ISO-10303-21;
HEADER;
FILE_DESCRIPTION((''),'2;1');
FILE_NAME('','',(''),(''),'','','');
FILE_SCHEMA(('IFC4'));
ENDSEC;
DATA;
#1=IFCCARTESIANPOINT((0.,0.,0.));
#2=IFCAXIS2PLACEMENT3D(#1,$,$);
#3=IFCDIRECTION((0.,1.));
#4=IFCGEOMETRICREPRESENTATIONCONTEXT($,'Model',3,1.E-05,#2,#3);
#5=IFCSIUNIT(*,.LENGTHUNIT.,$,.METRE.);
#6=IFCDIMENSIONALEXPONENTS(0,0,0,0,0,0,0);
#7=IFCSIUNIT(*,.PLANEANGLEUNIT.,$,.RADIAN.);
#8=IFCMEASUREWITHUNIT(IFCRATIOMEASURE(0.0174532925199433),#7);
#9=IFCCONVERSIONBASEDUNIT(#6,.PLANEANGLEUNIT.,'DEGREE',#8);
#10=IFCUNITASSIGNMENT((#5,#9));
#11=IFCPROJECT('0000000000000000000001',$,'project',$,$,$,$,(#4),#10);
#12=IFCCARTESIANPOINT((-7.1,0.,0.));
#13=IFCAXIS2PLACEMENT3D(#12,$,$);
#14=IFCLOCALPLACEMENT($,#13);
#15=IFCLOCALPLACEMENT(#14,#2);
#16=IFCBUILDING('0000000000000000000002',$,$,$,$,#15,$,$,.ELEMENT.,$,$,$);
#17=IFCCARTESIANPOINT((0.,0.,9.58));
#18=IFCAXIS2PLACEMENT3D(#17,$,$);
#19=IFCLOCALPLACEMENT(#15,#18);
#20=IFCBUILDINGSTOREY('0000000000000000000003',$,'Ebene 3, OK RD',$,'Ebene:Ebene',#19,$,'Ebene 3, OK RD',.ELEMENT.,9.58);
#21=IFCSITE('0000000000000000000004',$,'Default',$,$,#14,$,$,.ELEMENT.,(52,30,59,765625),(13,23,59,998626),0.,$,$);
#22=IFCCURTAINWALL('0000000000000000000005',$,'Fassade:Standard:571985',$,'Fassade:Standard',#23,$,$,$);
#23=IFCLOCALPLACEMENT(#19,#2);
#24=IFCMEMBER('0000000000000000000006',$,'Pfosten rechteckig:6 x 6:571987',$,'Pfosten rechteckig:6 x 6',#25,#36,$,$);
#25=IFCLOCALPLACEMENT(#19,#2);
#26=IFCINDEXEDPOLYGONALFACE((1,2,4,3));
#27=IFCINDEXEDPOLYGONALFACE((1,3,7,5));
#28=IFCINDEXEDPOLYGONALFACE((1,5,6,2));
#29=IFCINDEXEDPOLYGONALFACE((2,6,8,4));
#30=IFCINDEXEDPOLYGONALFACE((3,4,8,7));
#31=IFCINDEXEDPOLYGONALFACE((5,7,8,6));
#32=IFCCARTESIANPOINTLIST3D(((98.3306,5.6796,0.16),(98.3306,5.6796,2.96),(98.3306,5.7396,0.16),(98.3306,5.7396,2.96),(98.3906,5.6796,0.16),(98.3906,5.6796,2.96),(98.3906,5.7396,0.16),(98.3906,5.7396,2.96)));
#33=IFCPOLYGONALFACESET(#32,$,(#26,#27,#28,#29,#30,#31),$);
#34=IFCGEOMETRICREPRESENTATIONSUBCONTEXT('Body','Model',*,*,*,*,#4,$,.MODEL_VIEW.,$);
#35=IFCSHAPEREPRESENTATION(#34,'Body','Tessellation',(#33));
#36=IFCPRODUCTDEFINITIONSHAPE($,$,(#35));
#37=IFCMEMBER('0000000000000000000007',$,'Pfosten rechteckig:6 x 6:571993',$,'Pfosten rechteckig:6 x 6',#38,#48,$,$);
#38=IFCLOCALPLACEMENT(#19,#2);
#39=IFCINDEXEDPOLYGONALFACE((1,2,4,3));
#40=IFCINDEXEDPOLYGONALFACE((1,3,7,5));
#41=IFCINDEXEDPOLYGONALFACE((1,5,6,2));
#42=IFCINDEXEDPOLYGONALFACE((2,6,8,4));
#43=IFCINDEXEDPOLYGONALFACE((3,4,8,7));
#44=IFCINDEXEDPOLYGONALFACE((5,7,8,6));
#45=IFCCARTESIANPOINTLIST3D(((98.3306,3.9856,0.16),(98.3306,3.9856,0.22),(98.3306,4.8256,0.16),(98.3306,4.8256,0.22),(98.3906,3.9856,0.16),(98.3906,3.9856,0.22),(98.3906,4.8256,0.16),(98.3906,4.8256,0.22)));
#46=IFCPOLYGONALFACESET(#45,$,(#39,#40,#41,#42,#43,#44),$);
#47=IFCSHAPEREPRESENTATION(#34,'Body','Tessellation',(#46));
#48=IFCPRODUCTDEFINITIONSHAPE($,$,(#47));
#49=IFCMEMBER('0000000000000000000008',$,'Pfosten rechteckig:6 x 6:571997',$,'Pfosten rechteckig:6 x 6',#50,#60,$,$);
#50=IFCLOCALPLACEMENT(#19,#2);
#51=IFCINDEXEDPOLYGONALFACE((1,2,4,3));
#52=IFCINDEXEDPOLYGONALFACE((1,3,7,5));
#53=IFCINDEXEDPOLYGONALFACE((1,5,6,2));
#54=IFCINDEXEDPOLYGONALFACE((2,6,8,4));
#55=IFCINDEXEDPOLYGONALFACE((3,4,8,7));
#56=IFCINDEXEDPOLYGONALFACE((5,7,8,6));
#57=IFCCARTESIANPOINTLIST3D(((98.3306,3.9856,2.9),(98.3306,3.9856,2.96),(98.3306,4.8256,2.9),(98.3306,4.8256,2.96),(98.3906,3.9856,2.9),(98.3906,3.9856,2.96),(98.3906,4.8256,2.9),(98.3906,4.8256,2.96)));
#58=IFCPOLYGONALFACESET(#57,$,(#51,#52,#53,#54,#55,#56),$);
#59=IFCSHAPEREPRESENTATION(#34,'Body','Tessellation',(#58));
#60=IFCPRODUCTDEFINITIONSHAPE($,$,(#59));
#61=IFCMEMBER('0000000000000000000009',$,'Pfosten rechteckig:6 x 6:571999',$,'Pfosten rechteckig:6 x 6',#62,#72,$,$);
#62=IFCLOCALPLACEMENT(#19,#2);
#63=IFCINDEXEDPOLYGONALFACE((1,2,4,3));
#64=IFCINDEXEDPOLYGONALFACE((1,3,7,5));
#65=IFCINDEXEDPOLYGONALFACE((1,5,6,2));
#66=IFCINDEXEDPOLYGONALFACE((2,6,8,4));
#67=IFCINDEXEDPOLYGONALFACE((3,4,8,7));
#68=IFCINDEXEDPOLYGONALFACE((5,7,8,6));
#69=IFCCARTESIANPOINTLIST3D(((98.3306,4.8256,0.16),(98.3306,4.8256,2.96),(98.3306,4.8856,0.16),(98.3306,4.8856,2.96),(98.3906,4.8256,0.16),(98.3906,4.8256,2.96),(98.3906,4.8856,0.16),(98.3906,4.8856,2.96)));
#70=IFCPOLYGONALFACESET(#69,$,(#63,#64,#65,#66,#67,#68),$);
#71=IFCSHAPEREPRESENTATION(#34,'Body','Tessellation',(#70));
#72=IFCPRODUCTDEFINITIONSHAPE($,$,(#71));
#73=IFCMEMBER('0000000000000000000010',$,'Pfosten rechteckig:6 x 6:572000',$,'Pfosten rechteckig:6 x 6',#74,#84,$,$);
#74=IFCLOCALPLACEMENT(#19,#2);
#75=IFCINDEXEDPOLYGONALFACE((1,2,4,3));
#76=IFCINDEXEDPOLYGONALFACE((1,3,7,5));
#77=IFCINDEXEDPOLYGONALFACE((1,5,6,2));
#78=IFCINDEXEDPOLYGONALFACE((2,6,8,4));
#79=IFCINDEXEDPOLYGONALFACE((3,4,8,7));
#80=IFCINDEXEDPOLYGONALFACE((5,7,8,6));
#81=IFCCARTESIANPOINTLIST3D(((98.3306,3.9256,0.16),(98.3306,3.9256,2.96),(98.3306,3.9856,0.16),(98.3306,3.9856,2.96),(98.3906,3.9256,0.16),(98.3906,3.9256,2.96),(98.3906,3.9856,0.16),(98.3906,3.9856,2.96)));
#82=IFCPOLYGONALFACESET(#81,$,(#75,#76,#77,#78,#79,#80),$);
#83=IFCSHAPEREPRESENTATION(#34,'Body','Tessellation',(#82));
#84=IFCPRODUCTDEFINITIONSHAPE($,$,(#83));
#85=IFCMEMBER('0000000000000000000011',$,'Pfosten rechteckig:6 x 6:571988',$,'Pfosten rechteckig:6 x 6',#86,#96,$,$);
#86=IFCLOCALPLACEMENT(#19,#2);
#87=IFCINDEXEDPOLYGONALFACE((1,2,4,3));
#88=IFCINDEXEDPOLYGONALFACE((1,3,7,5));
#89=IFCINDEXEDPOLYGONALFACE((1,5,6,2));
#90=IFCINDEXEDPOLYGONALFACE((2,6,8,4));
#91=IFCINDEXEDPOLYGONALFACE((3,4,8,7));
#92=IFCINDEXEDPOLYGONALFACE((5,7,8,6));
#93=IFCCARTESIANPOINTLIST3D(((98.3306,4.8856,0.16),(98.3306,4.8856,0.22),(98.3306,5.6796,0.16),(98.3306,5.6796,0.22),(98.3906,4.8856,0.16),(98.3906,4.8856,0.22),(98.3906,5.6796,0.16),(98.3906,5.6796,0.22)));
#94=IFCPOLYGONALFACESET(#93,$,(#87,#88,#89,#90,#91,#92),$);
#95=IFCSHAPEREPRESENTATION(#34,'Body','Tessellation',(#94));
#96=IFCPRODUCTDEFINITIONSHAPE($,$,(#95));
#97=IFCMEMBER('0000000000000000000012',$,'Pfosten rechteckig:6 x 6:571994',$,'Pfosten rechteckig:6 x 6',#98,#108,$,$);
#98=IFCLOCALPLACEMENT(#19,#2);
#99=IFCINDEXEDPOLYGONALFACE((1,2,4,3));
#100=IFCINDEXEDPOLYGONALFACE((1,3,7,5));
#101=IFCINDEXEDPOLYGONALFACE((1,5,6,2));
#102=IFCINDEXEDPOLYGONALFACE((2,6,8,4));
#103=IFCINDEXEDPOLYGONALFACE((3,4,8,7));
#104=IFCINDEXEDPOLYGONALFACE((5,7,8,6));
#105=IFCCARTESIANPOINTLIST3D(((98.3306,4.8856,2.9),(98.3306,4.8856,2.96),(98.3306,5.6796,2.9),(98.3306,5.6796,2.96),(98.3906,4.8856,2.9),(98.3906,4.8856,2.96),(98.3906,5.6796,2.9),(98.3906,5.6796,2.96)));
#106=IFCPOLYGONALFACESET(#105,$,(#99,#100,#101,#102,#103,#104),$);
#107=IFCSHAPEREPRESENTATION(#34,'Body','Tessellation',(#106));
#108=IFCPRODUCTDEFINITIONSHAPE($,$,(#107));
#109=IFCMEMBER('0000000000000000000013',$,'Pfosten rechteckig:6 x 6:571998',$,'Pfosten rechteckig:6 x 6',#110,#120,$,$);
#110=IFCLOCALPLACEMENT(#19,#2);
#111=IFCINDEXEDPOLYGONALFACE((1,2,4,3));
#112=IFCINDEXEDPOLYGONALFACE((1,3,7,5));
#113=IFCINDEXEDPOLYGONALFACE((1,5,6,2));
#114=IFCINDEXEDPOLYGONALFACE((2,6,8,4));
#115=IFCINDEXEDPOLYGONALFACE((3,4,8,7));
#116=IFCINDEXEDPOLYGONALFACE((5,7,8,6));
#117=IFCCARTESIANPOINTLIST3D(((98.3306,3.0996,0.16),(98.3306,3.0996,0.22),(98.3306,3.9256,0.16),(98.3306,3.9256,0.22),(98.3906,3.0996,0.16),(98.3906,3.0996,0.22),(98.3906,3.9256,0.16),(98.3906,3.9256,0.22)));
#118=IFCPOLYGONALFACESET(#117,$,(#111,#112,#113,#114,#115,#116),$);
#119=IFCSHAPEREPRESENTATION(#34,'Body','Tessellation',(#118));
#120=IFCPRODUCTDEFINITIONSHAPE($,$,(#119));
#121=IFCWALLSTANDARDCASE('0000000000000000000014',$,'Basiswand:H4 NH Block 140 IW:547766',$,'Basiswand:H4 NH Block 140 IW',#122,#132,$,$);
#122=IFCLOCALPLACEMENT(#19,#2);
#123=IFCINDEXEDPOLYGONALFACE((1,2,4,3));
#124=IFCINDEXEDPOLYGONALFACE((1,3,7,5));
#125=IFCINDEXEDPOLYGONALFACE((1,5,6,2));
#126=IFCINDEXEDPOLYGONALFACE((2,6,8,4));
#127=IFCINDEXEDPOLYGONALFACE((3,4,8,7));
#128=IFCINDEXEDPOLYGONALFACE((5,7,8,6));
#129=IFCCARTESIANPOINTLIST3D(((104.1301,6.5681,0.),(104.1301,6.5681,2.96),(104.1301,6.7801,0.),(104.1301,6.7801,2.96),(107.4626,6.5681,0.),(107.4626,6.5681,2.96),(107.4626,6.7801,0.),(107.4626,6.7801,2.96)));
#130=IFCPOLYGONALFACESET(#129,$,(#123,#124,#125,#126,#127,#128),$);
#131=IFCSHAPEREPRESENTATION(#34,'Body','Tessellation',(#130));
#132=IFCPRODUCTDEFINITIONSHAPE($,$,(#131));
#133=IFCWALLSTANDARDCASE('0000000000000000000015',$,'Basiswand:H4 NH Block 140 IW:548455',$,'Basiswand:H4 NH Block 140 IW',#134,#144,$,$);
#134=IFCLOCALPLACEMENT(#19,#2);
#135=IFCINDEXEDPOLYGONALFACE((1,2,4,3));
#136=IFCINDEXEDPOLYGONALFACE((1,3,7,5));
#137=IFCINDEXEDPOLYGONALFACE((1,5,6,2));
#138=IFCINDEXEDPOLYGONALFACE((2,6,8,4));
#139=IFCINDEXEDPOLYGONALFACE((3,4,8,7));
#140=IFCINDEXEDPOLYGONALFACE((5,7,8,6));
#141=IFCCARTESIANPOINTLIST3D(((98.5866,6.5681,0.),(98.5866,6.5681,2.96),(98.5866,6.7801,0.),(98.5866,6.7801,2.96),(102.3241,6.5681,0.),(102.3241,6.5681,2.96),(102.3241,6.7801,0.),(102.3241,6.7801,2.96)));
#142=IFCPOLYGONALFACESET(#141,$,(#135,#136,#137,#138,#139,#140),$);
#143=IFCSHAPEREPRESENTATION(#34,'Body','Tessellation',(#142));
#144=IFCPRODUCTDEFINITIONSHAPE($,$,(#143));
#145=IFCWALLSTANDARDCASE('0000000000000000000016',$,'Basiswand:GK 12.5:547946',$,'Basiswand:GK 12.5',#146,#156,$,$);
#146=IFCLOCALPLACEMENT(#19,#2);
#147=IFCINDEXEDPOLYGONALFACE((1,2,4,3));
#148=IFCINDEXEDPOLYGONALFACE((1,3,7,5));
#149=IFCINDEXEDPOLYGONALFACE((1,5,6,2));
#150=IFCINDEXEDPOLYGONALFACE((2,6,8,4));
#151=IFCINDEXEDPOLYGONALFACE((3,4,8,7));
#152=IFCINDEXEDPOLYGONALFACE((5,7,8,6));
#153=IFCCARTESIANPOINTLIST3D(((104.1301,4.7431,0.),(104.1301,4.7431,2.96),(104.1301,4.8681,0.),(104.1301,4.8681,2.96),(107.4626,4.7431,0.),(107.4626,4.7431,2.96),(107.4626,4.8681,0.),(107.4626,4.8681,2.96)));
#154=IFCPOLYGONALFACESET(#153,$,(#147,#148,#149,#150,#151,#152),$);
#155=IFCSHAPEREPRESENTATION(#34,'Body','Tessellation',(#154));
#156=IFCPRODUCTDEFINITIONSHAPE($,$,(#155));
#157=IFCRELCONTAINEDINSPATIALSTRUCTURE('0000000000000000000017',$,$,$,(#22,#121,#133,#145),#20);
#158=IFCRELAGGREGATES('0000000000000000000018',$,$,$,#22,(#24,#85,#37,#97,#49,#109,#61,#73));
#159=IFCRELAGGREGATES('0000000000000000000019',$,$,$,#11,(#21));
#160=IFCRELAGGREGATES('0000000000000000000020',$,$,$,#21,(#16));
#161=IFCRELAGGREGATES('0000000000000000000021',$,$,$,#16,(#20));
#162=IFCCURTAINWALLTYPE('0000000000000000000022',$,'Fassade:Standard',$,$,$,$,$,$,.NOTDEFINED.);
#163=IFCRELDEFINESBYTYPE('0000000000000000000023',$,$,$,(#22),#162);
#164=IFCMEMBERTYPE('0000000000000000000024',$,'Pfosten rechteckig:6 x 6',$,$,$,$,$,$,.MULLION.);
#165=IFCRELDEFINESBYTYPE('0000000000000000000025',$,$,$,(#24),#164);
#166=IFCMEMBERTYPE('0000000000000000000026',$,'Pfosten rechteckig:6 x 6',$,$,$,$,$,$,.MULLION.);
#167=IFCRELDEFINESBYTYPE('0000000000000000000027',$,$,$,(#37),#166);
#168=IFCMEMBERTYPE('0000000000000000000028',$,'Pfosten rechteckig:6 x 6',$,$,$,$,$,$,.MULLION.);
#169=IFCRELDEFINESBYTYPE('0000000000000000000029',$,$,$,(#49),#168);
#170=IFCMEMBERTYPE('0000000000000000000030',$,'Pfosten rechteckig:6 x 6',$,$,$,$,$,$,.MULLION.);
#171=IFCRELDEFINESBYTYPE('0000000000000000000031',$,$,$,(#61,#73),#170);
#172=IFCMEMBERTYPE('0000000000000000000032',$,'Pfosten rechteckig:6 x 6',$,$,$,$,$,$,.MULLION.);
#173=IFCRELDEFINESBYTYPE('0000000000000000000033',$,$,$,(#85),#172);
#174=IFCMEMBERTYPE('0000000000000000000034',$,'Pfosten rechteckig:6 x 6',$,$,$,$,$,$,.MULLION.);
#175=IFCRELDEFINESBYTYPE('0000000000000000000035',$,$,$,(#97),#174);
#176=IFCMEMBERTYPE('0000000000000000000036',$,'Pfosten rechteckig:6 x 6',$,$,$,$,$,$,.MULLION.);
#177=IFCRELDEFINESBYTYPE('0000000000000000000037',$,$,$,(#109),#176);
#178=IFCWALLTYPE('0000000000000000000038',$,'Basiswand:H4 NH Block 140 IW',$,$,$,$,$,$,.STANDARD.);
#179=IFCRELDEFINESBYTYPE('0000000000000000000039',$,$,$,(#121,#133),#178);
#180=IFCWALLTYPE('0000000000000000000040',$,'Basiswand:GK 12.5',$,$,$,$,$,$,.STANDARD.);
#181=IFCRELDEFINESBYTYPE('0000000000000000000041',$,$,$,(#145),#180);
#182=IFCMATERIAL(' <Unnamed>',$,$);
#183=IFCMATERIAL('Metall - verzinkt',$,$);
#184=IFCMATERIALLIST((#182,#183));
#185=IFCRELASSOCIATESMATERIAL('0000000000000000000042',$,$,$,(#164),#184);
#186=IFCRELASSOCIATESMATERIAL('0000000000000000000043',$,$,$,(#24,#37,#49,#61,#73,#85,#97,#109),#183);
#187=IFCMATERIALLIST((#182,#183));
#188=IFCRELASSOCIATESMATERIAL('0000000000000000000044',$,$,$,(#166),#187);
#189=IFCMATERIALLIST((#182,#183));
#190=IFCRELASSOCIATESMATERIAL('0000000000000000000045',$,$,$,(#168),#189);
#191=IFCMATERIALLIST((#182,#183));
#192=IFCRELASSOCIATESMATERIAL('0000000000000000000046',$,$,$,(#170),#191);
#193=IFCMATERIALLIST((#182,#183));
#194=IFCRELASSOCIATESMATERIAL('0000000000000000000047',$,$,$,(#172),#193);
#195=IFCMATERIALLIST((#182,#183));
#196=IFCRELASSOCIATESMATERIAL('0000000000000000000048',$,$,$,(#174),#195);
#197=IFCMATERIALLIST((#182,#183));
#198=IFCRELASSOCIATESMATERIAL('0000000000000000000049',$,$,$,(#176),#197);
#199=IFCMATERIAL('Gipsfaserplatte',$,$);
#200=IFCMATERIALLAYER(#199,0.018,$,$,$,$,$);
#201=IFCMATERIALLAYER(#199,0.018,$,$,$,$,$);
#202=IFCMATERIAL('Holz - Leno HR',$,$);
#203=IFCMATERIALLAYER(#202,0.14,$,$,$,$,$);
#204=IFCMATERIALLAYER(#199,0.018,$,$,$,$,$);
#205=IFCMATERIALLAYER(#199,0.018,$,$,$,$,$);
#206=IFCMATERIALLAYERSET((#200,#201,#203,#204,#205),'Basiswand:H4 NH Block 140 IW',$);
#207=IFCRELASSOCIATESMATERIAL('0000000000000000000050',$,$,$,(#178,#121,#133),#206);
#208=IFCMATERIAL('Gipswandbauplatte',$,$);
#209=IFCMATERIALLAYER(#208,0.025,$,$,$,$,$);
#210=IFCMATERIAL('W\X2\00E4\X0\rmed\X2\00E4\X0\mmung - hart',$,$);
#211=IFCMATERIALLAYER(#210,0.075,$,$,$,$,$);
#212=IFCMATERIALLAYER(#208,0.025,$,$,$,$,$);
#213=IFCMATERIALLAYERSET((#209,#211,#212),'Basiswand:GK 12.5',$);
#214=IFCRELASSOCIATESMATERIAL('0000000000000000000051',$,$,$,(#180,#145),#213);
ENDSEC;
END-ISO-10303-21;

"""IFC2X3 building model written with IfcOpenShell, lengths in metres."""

from ifc_helpers import new_model, entity, si_unit, converted_unit, direction, frame, frame_2d, origin, origin_2d_with_axis, place, context, subcontext, project, spatial, rectangle, extrude, source, transform, mapped, material, material_list, layer, layer_set, layer_usage, type_object, type_shapes, element, aggregate, save


model = new_model("IFC2X3")

# Units and contexts
model_context = context("Model", 3, precision=1e-05, world=origin(), true_north=direction((0.0, 1.0)))
body_context = subcontext(model_context, "Body", "Model", "MODEL_VIEW")
ifc_project = project(units=[si_unit("LENGTHUNIT", "METRE"), converted_unit("PLANEANGLEUNIT", "DEGREE", entity("IfcRatioMeasure", 0.0174532925199433), si_unit("PLANEANGLEUNIT", "RADIAN"), dimensions=[0, 0, 0, 0, 0, 0, 0])], contexts=[model_context])

# Site, building, storey
site_placement = place(None, frame((-7.1, 0.0, 0.0)))
site = spatial("IfcSite", under=ifc_project, at=site_placement, Name="Default", CompositionType="ELEMENT", RefLatitude=(52, 30, 59, 765625), RefLongitude=(13, 23, 59, 998626), RefElevation=0.0)
building_placement = place(site_placement, origin())
building = spatial("IfcBuilding", under=site, at=building_placement, CompositionType="ELEMENT")
storey_placement = place(building_placement, frame((0.0, 0.0, 9.58)))
storey = spatial("IfcBuildingStorey", under=building, at=storey_placement, Name="Ebene 3, OK RD", ObjectType="Ebene:Ebene", LongName="Ebene 3, OK RD", CompositionType="ELEMENT", Elevation=9.58)

# Curtain wall, members
curtain_wall_type = type_object("IfcCurtainWallType", Name="Fassade:Standard", PredefinedType="NOTDEFINED")
curtain_wall_placement = place(storey_placement, frame((0.0, 0.0, -9.58)))
curtain_wall = element("IfcCurtainWall", 1, at=curtain_wall_placement, inside=storey, type_object=curtain_wall_type, Name="Fassade:Standard:571985", ObjectType="Fassade:Standard")
ifc_material_1 = material(Name="Metall - verzinkt")
ifc_material_2 = material(Name=" <Unnamed>")
ifc_material_list_1 = material_list([ifc_material_2, ifc_material_1])
member_type_1 = type_object("IfcMemberType", Name="Pfosten rechteckig:6 x 6", PredefinedType="MULLION", material=ifc_material_list_1)
shared_shape_1 = source(origin(), body_context, "Body", "SweptSolid", [
    extrude(rectangle(XDim=0.06, YDim=0.06, at=origin_2d_with_axis()), frame((-0.03, 0.0, -2.8), z_axis=(0.0, 0.0, 1.0), x_axis=(0.0, -1.0, 0.0)), (0.0, 0.0, 1.0), 2.8),
])
type_shapes(member_type_1, [shared_shape_1])
member_1_placement = place(storey_placement, frame((98.3606, 5.7396, 2.96), z_axis=(0.0, 0.0, 1.0), x_axis=(0.0, 1.0, 0.0)))
member_1 = element("IfcMember", 2, at=member_1_placement, type_object=member_type_1, material=ifc_material_1, Name="Pfosten rechteckig:6 x 6:571987", ObjectType="Pfosten rechteckig:6 x 6", context=body_context, shape_type="MappedRepresentation", body=[
    mapped(shared_shape_1, transform((0.0, 0.0, 0.0), scale=1.0)),
])
ifc_material_list_2 = material_list([ifc_material_2, ifc_material_1])
member_type_2 = type_object("IfcMemberType", Name="Pfosten rechteckig:6 x 6", PredefinedType="MULLION", material=ifc_material_list_2)
shared_shape_2 = source(origin(), body_context, "Body", "SweptSolid", [
    extrude(rectangle(XDim=0.06, YDim=0.06, at=origin_2d_with_axis()), frame((-0.03, 0.0, -0.84), z_axis=(0.0, 0.0, 1.0), x_axis=(0.0, -1.0, 0.0)), (0.0, 0.0, 1.0), 0.84),
])
type_shapes(member_type_2, [shared_shape_2])
member_2_placement = place(storey_placement, frame((98.3606, 4.8256, 0.16), z_axis=(0.0, 1.0, 0.0), x_axis=(0.0, 0.0, -1.0)))
member_2 = element("IfcMember", 3, at=member_2_placement, type_object=member_type_2, material=ifc_material_1, Name="Pfosten rechteckig:6 x 6:571993", ObjectType="Pfosten rechteckig:6 x 6", context=body_context, shape_type="MappedRepresentation", body=[
    mapped(shared_shape_2, transform((0.0, 0.0, 0.0), scale=1.0)),
])
ifc_material_list_3 = material_list([ifc_material_2, ifc_material_1])
member_type_3 = type_object("IfcMemberType", Name="Pfosten rechteckig:6 x 6", PredefinedType="MULLION", material=ifc_material_list_3)
shared_shape_3 = source(origin(), body_context, "Body", "SweptSolid", [
    extrude(rectangle(XDim=0.06, YDim=0.06, at=origin_2d_with_axis()), frame((-0.03, 0.0, -0.84), z_axis=(0.0, 0.0, 1.0), x_axis=(0.0, -1.0, 0.0)), (0.0, 0.0, 1.0), 0.84),
])
type_shapes(member_type_3, [shared_shape_3])
member_3_placement = place(storey_placement, frame((98.3606, 3.9856, 2.96), z_axis=(0.0, -1.0, 0.0), x_axis=(0.0, 0.0, 1.0)))
member_3 = element("IfcMember", 4, at=member_3_placement, type_object=member_type_3, material=ifc_material_1, Name="Pfosten rechteckig:6 x 6:571997", ObjectType="Pfosten rechteckig:6 x 6", context=body_context, shape_type="MappedRepresentation", body=[
    mapped(shared_shape_3, transform((0.0, 0.0, 0.0), scale=1.0)),
])
ifc_material_list_4 = material_list([ifc_material_2, ifc_material_1])
member_type_4 = type_object("IfcMemberType", Name="Pfosten rechteckig:6 x 6", PredefinedType="MULLION", material=ifc_material_list_4)
shared_shape_4 = source(origin(), body_context, "Body", "SweptSolid", [
    extrude(rectangle(XDim=0.06, YDim=0.06, at=origin_2d_with_axis()), frame((0.0, 0.0, -2.8), z_axis=(0.0, 0.0, 1.0), x_axis=(0.0, -1.0, 0.0)), (0.0, 0.0, 1.0), 2.8),
])
type_shapes(member_type_4, [shared_shape_4])
member_4_placement = place(storey_placement, frame((98.3606, 4.8556, 0.16), z_axis=(0.0, 0.0, -1.0), x_axis=(0.0, -1.0, 0.0)))
member_4 = element("IfcMember", 5, at=member_4_placement, type_object=member_type_4, material=ifc_material_1, Name="Pfosten rechteckig:6 x 6:571999", ObjectType="Pfosten rechteckig:6 x 6", context=body_context, shape_type="MappedRepresentation", body=[
    mapped(shared_shape_4, transform((0.0, 0.0, 0.0), scale=1.0)),
])
member_5_placement = place(storey_placement, frame((98.3606, 3.9556, 0.16), z_axis=(0.0, 0.0, -1.0), x_axis=(0.0, -1.0, 0.0)))
member_5 = element("IfcMember", 6, at=member_5_placement, type_object=member_type_4, material=ifc_material_1, Name="Pfosten rechteckig:6 x 6:572000", ObjectType="Pfosten rechteckig:6 x 6", context=body_context, shape_type="MappedRepresentation", body=[
    mapped(shared_shape_4, transform((0.0, 0.0, 0.0), scale=1.0)),
])
ifc_material_list_5 = material_list([ifc_material_2, ifc_material_1])
member_type_5 = type_object("IfcMemberType", Name="Pfosten rechteckig:6 x 6", PredefinedType="MULLION", material=ifc_material_list_5)
shared_shape_5 = source(origin(), body_context, "Body", "SweptSolid", [
    extrude(rectangle(XDim=0.06, YDim=0.06, at=origin_2d_with_axis()), frame((-0.03, 0.0, -0.794), z_axis=(0.0, 0.0, 1.0), x_axis=(0.0, -1.0, 0.0)), (0.0, 0.0, 1.0), 0.794),
])
type_shapes(member_type_5, [shared_shape_5])
member_6_placement = place(storey_placement, frame((98.3606, 5.6796, 0.16), z_axis=(0.0, 1.0, 0.0), x_axis=(0.0, 0.0, -1.0)))
member_6 = element("IfcMember", 7, at=member_6_placement, type_object=member_type_5, material=ifc_material_1, Name="Pfosten rechteckig:6 x 6:571988", ObjectType="Pfosten rechteckig:6 x 6", context=body_context, shape_type="MappedRepresentation", body=[
    mapped(shared_shape_5, transform((0.0, 0.0, 0.0), scale=1.0)),
])
ifc_material_list_6 = material_list([ifc_material_2, ifc_material_1])
member_type_6 = type_object("IfcMemberType", Name="Pfosten rechteckig:6 x 6", PredefinedType="MULLION", material=ifc_material_list_6)
shared_shape_6 = source(origin(), body_context, "Body", "SweptSolid", [
    extrude(rectangle(XDim=0.06, YDim=0.06, at=origin_2d_with_axis()), frame((-0.03, 0.0, -0.794), z_axis=(0.0, 0.0, 1.0), x_axis=(0.0, -1.0, 0.0)), (0.0, 0.0, 1.0), 0.794),
])
type_shapes(member_type_6, [shared_shape_6])
member_7_placement = place(storey_placement, frame((98.3606, 4.8856, 2.96), z_axis=(0.0, -1.0, 0.0), x_axis=(0.0, 0.0, 1.0)))
member_7 = element("IfcMember", 8, at=member_7_placement, type_object=member_type_6, material=ifc_material_1, Name="Pfosten rechteckig:6 x 6:571994", ObjectType="Pfosten rechteckig:6 x 6", context=body_context, shape_type="MappedRepresentation", body=[
    mapped(shared_shape_6, transform((0.0, 0.0, 0.0), scale=1.0)),
])
ifc_material_list_7 = material_list([ifc_material_2, ifc_material_1])
member_type_7 = type_object("IfcMemberType", Name="Pfosten rechteckig:6 x 6", PredefinedType="MULLION", material=ifc_material_list_7)
shared_shape_7 = source(origin(), body_context, "Body", "SweptSolid", [
    extrude(rectangle(XDim=0.06, YDim=0.06, at=origin_2d_with_axis()), frame((-0.03, 0.0, -0.826), z_axis=(0.0, 0.0, 1.0), x_axis=(0.0, -1.0, 0.0)), (0.0, 0.0, 1.0), 0.826),
])
type_shapes(member_type_7, [shared_shape_7])
member_8_placement = place(storey_placement, frame((98.3606, 3.9256, 0.16), z_axis=(0.0, 1.0, 0.0), x_axis=(0.0, 0.0, -1.0)))
member_8 = element("IfcMember", 9, at=member_8_placement, type_object=member_type_7, material=ifc_material_1, Name="Pfosten rechteckig:6 x 6:571998", ObjectType="Pfosten rechteckig:6 x 6", context=body_context, shape_type="MappedRepresentation", body=[
    mapped(shared_shape_7, transform((0.0, 0.0, 0.0), scale=1.0)),
])
aggregate(curtain_wall, [member_1, member_6, member_2, member_7, member_3, member_8, member_4, member_5])

# Walls
ifc_material_3 = material(Name="Gipsfaserplatte")
ifc_layer_1 = layer(ifc_material_3, 0.018)
ifc_layer_2 = layer(ifc_material_3, 0.018)
ifc_material_4 = material(Name="Holz - Leno HR")
ifc_layer_3 = layer(ifc_material_4, 0.14)
ifc_layer_4 = layer(ifc_material_3, 0.018)
ifc_layer_5 = layer(ifc_material_3, 0.018)
ifc_layer_set_1 = layer_set([ifc_layer_1, ifc_layer_2, ifc_layer_3, ifc_layer_4, ifc_layer_5], Name="Basiswand:H4 NH Block 140 IW")
ifc_layer_usage_1 = layer_usage(ifc_layer_set_1, "AXIS2", "NEGATIVE", 0.106)
wall_type_1 = type_object("IfcWallType", Name="Basiswand:H4 NH Block 140 IW", PredefinedType="STANDARD", material=ifc_layer_set_1)
wall_1_placement = place(storey_placement, frame((104.1301, 6.6741, 0.0)))
element("IfcWallStandardCase", 10, at=wall_1_placement, inside=storey, type_object=wall_type_1, material=ifc_layer_usage_1, Name="Basiswand:H4 NH Block 140 IW:547766", ObjectType="Basiswand:H4 NH Block 140 IW", context=body_context, shape_type="SweptSolid", body=[
    extrude(rectangle(XDim=3.3325, YDim=0.212, at=frame_2d((1.6663, 0.0), x_axis=(-1.0, 0.0))), origin(), (0.0, 0.0, 1.0), 2.96),
])
ifc_layer_usage_2 = layer_usage(ifc_layer_set_1, "AXIS2", "NEGATIVE", 0.106)
wall_2_placement = place(storey_placement, frame((98.5866, 6.6741, 0.0)))
element("IfcWallStandardCase", 11, at=wall_2_placement, inside=storey, type_object=wall_type_1, material=ifc_layer_usage_2, Name="Basiswand:H4 NH Block 140 IW:548455", ObjectType="Basiswand:H4 NH Block 140 IW", context=body_context, shape_type="SweptSolid", body=[
    extrude(rectangle(XDim=3.7375, YDim=0.212, at=frame_2d((1.8687, 0.0), x_axis=(-1.0, 0.0))), origin(), (0.0, 0.0, 1.0), 2.96),
])
ifc_material_5 = material(Name="Gipswandbauplatte")
ifc_layer_6 = layer(ifc_material_5, 0.025)
ifc_material_6 = material(Name="Wärmedämmung - hart")
ifc_layer_7 = layer(ifc_material_6, 0.075)
ifc_layer_8 = layer(ifc_material_5, 0.025)
ifc_layer_set_2 = layer_set([ifc_layer_6, ifc_layer_7, ifc_layer_8], Name="Basiswand:GK 12.5")
ifc_layer_usage_3 = layer_usage(ifc_layer_set_2, "AXIS2", "NEGATIVE", 0.0625)
wall_type_2 = type_object("IfcWallType", Name="Basiswand:GK 12.5", PredefinedType="STANDARD", material=ifc_layer_set_2)
wall_3_placement = place(storey_placement, frame((104.1301, 4.8056, 0.0)))
element("IfcWallStandardCase", 12, at=wall_3_placement, inside=storey, type_object=wall_type_2, material=ifc_layer_usage_3, Name="Basiswand:GK 12.5:547946", ObjectType="Basiswand:GK 12.5", context=body_context, shape_type="SweptSolid", body=[
    extrude(rectangle(XDim=3.3325, YDim=0.125, at=frame_2d((1.6663, 0.0), x_axis=(-1.0, 0.0))), origin(), (0.0, 0.0, 1.0), 2.96),
])

save(model, "model.ifc")
